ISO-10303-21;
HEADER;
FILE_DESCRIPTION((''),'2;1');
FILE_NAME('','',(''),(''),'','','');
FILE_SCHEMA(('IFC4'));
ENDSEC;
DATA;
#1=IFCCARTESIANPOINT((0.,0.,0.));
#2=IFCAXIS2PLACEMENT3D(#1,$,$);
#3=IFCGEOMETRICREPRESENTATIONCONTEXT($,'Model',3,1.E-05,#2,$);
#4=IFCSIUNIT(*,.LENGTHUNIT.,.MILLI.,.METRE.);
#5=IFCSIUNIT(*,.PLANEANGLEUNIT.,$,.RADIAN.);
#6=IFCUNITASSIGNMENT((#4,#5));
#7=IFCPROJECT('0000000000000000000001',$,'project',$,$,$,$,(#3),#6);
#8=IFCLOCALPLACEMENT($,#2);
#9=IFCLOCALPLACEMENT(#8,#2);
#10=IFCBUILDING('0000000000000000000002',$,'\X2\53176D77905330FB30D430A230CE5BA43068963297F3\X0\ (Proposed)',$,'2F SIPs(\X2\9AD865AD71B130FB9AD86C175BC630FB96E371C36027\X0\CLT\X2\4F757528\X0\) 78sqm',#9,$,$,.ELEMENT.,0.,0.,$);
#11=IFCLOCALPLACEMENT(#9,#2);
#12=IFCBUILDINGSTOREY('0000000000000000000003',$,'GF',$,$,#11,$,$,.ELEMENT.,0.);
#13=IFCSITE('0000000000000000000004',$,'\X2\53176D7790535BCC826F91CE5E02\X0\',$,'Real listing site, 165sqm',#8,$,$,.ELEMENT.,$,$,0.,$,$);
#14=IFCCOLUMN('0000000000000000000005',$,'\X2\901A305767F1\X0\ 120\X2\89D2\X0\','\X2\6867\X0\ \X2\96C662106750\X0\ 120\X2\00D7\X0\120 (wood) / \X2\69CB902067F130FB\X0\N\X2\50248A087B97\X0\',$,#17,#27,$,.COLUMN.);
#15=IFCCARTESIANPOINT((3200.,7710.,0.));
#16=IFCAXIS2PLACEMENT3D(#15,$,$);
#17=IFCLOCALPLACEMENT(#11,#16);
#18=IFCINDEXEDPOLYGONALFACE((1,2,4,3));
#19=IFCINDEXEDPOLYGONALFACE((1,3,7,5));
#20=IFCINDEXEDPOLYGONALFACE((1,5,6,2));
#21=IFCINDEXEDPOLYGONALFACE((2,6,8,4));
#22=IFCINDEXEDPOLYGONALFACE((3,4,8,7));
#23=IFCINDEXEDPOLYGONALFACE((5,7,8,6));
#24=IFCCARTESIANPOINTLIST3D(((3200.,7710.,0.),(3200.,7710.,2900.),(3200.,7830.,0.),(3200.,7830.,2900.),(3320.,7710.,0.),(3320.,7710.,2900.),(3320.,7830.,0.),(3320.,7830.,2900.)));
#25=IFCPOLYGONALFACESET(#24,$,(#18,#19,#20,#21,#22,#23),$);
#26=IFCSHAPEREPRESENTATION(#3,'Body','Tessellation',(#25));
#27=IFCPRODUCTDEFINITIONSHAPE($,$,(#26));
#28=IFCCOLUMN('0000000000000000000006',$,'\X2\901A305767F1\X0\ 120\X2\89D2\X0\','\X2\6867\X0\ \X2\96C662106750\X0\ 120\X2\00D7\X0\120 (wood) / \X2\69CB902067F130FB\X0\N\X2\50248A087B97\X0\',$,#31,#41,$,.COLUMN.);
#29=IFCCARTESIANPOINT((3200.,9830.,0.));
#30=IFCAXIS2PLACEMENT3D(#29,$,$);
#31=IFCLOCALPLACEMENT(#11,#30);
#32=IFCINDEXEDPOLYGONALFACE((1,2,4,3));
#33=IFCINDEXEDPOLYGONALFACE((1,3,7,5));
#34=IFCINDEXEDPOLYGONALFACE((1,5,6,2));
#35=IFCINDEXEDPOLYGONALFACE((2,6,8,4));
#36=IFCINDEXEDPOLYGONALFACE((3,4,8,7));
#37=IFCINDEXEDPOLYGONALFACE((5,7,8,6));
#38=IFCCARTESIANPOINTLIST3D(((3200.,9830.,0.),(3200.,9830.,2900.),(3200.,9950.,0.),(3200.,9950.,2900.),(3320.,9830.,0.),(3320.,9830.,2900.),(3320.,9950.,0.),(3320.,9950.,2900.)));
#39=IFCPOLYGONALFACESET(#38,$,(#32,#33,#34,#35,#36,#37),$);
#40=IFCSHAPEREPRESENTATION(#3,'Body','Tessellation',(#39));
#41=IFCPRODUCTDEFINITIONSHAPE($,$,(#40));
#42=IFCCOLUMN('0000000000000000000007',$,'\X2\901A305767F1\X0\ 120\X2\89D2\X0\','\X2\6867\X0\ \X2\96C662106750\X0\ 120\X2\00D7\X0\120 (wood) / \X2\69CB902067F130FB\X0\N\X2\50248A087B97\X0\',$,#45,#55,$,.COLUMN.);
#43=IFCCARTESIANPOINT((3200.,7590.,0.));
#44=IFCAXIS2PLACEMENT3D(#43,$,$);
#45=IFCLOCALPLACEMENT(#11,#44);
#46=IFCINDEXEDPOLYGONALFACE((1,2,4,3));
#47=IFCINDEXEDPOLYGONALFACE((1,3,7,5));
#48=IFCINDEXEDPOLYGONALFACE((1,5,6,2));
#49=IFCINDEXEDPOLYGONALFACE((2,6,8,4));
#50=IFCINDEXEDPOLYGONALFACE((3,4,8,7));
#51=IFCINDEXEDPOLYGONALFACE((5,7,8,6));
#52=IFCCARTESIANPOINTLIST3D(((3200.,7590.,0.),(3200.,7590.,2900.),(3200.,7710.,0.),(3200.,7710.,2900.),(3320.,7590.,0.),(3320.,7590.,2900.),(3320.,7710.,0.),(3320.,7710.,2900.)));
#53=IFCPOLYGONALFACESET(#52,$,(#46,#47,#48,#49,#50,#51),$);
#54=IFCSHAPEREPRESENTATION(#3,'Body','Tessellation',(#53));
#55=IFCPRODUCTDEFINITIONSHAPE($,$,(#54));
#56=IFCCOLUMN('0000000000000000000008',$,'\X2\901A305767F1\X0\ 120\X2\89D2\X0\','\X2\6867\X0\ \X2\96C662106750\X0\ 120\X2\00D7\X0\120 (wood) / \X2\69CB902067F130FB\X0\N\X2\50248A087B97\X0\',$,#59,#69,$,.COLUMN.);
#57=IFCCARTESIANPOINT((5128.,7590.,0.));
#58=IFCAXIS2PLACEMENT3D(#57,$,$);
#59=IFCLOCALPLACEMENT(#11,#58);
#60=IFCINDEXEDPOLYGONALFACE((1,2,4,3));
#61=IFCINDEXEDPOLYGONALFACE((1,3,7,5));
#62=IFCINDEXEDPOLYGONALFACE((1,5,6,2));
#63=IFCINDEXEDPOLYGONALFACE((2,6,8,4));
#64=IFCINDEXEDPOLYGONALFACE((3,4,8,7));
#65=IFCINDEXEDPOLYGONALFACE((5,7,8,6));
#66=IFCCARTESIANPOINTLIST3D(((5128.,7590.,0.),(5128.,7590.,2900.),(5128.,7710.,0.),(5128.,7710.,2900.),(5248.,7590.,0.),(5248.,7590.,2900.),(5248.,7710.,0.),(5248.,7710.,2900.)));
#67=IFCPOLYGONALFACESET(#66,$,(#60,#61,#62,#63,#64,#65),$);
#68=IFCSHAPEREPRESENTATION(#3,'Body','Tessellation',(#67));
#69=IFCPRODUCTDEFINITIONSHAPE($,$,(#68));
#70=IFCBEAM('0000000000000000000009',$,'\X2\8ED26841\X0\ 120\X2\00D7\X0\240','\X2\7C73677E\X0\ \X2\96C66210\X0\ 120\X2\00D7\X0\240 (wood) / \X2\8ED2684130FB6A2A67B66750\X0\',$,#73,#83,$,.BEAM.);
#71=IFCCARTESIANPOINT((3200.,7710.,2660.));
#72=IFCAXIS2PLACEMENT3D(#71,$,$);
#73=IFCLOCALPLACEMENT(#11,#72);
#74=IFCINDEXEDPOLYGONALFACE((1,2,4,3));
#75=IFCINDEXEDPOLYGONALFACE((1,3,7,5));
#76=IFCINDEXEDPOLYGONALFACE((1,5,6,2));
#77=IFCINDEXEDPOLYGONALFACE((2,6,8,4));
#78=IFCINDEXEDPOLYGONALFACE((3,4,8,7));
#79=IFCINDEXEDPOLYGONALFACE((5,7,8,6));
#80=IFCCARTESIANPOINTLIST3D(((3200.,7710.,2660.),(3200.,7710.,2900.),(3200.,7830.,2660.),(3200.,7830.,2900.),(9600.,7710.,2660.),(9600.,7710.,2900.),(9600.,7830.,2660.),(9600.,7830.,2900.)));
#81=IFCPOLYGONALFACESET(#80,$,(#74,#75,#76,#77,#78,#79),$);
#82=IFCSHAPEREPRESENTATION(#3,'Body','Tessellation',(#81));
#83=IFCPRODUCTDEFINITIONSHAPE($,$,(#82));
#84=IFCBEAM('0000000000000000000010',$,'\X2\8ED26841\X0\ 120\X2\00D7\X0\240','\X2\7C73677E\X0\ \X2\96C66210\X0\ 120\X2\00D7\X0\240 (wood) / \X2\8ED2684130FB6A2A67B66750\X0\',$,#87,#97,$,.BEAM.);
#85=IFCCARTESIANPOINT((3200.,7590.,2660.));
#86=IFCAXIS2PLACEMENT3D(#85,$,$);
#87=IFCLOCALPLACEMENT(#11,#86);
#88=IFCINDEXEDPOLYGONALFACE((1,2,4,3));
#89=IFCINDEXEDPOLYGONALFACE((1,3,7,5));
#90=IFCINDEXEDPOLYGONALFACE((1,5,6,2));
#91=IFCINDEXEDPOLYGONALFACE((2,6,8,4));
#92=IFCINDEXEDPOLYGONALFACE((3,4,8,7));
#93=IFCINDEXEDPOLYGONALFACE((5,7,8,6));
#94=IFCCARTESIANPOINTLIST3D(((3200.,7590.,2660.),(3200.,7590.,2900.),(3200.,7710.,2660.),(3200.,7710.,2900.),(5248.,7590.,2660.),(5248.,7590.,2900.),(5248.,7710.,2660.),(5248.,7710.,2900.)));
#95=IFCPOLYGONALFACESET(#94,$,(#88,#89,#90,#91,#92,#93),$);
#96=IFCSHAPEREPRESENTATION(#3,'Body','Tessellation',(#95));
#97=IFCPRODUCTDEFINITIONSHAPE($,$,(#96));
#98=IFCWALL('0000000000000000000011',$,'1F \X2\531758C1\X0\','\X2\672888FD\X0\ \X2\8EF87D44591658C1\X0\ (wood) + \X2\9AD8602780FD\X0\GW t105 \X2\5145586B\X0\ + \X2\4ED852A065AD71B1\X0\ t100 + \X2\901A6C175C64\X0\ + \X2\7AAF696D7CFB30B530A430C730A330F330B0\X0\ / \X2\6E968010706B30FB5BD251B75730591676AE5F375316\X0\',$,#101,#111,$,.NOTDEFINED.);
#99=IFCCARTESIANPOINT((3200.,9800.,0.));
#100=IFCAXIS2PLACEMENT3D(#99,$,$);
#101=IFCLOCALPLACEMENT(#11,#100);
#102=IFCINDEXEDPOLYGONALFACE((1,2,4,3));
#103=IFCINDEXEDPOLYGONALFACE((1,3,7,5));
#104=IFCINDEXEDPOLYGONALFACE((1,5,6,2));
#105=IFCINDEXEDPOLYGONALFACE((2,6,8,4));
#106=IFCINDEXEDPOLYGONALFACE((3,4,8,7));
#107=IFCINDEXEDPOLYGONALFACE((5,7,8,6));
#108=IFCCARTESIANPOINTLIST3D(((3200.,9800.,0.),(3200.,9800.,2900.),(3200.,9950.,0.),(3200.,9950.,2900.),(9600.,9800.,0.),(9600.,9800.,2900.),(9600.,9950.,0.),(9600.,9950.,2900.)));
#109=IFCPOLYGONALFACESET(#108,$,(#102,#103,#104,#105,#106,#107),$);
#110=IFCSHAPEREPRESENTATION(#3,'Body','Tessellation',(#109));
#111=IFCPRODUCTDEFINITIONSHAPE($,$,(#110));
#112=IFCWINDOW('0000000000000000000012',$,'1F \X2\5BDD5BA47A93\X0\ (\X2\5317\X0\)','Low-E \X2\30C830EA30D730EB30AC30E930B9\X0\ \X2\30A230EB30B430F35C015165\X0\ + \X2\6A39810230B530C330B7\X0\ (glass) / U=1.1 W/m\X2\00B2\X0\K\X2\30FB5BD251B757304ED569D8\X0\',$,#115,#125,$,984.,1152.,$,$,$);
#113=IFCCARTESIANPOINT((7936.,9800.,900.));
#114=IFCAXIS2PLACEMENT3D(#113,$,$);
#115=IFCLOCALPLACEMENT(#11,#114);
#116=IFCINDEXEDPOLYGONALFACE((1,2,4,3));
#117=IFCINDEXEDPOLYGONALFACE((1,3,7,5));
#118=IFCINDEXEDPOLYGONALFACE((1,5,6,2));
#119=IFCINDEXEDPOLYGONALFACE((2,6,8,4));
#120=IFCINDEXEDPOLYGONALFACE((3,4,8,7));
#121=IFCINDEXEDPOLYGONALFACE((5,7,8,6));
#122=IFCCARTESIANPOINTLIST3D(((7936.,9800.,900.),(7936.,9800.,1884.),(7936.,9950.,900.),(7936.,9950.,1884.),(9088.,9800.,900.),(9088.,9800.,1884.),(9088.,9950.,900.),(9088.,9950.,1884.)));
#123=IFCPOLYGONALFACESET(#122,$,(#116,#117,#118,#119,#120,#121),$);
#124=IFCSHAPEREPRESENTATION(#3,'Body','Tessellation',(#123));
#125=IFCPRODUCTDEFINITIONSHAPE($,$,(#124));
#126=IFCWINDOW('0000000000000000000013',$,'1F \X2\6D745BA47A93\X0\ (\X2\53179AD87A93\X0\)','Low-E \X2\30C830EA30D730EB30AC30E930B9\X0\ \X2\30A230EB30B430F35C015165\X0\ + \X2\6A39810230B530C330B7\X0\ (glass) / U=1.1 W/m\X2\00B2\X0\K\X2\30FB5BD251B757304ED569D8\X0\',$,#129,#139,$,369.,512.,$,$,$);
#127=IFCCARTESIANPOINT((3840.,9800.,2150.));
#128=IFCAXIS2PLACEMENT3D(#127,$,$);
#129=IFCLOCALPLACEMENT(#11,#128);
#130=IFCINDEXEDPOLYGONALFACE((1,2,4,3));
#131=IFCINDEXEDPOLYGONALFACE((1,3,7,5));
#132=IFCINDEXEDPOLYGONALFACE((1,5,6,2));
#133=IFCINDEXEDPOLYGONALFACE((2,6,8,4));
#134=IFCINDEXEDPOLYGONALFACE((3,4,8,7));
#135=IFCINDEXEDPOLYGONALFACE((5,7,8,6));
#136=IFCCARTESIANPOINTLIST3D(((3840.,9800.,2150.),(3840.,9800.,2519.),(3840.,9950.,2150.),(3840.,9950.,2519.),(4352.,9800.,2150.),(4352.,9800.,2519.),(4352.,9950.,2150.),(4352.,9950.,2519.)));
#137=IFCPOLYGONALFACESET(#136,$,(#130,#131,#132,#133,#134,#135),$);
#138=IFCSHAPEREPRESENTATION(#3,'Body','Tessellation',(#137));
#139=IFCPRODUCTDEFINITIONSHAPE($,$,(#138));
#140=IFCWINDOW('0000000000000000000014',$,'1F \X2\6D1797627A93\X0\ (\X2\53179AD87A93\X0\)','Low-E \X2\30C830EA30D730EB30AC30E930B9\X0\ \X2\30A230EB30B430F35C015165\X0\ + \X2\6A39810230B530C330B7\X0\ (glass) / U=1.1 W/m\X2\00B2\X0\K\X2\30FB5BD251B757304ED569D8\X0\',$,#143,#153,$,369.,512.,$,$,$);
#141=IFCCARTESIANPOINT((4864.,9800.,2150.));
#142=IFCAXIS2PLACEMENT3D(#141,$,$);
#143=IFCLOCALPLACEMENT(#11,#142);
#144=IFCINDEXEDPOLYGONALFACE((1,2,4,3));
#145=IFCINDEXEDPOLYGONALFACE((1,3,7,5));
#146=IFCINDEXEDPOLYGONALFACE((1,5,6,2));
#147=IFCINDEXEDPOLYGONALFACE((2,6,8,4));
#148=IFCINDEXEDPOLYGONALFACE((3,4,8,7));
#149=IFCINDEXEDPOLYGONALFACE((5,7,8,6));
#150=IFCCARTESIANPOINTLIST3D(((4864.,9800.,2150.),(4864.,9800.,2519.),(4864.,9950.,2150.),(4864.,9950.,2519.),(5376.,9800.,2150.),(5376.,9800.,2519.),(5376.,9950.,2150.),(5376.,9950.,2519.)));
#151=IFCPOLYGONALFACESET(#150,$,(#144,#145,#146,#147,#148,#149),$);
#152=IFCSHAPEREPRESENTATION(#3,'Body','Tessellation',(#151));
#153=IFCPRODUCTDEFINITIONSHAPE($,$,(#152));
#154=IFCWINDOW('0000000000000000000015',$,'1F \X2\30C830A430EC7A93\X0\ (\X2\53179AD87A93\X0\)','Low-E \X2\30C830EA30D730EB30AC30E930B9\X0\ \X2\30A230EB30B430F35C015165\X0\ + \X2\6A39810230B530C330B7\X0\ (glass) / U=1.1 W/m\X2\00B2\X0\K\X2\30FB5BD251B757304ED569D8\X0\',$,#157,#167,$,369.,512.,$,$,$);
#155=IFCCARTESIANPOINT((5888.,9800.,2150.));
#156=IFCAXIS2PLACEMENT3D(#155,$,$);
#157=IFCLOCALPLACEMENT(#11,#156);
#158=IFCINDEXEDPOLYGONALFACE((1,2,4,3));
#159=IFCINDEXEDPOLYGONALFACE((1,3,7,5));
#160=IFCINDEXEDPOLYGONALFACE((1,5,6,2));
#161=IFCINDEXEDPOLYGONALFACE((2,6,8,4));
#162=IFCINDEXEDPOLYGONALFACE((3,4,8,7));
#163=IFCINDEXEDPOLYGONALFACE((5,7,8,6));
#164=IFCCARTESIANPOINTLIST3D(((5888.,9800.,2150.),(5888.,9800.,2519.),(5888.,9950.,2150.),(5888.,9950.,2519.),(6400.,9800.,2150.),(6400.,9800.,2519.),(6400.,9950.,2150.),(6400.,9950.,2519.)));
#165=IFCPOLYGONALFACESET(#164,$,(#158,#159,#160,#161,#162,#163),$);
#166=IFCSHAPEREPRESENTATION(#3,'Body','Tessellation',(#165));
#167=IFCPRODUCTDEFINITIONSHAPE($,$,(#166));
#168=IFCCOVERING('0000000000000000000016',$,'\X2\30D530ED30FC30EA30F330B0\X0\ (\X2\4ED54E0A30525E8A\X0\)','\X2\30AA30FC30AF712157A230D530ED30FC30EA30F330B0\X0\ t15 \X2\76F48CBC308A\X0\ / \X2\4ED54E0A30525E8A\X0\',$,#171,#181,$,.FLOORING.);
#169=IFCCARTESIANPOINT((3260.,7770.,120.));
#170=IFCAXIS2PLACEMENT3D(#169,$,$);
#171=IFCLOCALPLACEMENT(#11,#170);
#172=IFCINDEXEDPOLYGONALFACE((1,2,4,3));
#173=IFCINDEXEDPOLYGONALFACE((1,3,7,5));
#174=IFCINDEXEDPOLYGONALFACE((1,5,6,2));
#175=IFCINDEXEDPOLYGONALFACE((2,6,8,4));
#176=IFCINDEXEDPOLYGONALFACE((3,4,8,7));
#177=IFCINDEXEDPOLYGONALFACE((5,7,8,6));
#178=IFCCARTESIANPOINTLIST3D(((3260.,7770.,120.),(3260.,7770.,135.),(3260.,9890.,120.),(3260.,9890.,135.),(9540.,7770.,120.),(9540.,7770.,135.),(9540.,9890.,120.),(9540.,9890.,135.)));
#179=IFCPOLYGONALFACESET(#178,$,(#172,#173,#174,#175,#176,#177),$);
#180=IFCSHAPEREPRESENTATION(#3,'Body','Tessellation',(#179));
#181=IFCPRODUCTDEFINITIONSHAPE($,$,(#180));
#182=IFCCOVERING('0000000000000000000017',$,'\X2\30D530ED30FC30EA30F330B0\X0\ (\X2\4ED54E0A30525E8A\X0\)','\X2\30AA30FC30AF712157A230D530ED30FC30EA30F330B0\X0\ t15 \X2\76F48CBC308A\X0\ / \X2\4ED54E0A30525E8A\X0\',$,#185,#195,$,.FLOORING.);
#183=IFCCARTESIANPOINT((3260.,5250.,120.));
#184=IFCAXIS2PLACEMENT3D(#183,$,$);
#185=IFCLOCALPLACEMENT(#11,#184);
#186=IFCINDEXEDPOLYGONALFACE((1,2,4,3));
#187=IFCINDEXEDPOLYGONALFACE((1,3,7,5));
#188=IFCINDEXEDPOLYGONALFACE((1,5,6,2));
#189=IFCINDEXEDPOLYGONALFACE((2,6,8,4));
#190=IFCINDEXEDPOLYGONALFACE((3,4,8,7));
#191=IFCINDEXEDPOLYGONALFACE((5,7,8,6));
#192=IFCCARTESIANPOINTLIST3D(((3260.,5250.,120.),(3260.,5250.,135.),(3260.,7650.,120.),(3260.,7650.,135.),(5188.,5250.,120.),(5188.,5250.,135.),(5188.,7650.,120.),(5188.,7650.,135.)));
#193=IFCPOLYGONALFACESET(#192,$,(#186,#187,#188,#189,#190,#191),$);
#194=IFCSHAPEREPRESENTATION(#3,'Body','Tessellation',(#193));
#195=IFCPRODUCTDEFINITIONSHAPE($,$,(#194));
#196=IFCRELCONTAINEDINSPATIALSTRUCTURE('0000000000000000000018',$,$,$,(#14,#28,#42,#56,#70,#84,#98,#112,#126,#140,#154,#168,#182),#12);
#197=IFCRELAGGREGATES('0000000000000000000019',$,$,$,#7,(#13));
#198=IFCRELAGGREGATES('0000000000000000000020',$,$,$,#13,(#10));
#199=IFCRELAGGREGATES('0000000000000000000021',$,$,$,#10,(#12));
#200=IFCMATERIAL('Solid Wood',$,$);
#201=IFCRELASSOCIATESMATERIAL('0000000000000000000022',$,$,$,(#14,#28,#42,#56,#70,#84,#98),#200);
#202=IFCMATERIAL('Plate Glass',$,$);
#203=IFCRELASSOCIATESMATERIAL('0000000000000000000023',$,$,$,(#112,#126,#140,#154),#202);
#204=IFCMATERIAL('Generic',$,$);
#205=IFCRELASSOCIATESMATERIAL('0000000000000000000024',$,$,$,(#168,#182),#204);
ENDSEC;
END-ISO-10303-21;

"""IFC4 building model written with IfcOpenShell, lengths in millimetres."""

from ifc_helpers import new_model, si_unit, frame, frame_2d, origin, place, context, project, spatial, rectangle, extrude, material, element, fill, save


model = new_model("IFC4")

# Units and contexts
model_context = context("Model", 3, precision=1e-05, world=origin())
ifc_project = project(units=[si_unit("LENGTHUNIT", "METRE", prefix="MILLI"), si_unit("PLANEANGLEUNIT", "RADIAN")], contexts=[model_context])

# Site, building, storey
site_placement = place(None, origin())
site = spatial("IfcSite", under=ifc_project, at=site_placement, Name="北海道富良野市", ObjectType="Real listing site, 165sqm", CompositionType="ELEMENT", RefElevation=0.0)
building_placement = place(site_placement, origin())
building = spatial("IfcBuilding", under=site, at=building_placement, Name="北海道・ピアノ室と防音 (Proposed)", ObjectType="2F SIPs(高断熱・高気密・難燃性CLT併用) 78sqm", CompositionType="ELEMENT", ElevationOfRefHeight=0.0, ElevationOfTerrain=0.0)
storey_placement = place(building_placement, origin())
storey = spatial("IfcBuildingStorey", under=building, at=storey_placement, Name="GF", CompositionType="ELEMENT", Elevation=0.0)

# Columns
ifc_material_1 = material(Name="Solid Wood")
column_1_placement = place(storey_placement, frame((3200.0, 7710.0, 0.0)))
element("IfcColumn", 1, at=column_1_placement, inside=storey, material=ifc_material_1, Name="通し柱 120角", Description="桧 集成材 120×120 (wood) / 構造柱・N値計算", PredefinedType="COLUMN", context=model_context, shape_type="SweptSolid", body=[
    extrude(rectangle(XDim=120.0, YDim=120.0, at=frame_2d((60.0, 60.0))), frame((3200.0, 7710.0, 0.0)), (0.0, 0.0, 1.0), 2900.0),
])
column_2_placement = place(storey_placement, frame((3200.0, 9830.0, 0.0)))
element("IfcColumn", 2, at=column_2_placement, inside=storey, material=ifc_material_1, Name="通し柱 120角", Description="桧 集成材 120×120 (wood) / 構造柱・N値計算", PredefinedType="COLUMN", context=model_context, shape_type="SweptSolid", body=[
    extrude(rectangle(XDim=120.0, YDim=120.0, at=frame_2d((60.0, 60.0))), frame((3200.0, 9830.0, 0.0)), (0.0, 0.0, 1.0), 2900.0),
])
column_3_placement = place(storey_placement, frame((3200.0, 7590.0, 0.0)))
element("IfcColumn", 3, at=column_3_placement, inside=storey, material=ifc_material_1, Name="通し柱 120角", Description="桧 集成材 120×120 (wood) / 構造柱・N値計算", PredefinedType="COLUMN", context=model_context, shape_type="SweptSolid", body=[
    extrude(rectangle(XDim=120.0, YDim=120.0, at=frame_2d((60.0, 60.0))), frame((3200.0, 7590.0, 0.0)), (0.0, 0.0, 1.0), 2900.0),
])
column_4_placement = place(storey_placement, frame((5128.0, 7590.0, 0.0)))
element("IfcColumn", 4, at=column_4_placement, inside=storey, material=ifc_material_1, Name="通し柱 120角", Description="桧 集成材 120×120 (wood) / 構造柱・N値計算", PredefinedType="COLUMN", context=model_context, shape_type="SweptSolid", body=[
    extrude(rectangle(XDim=120.0, YDim=120.0, at=frame_2d((60.0, 60.0))), frame((5128.0, 7590.0, 0.0)), (0.0, 0.0, 1.0), 2900.0),
])

# Beams
beam_1_placement = place(storey_placement, frame((3200.0, 7710.0, 2660.0)))
element("IfcBeam", 5, at=beam_1_placement, inside=storey, material=ifc_material_1, Name="軒桁 120×240", Description="米松 集成 120×240 (wood) / 軒桁・横架材", PredefinedType="BEAM", context=model_context, shape_type="SweptSolid", body=[
    extrude(rectangle(XDim=6400.0, YDim=120.0, at=frame_2d((3200.0, 60.0))), frame((3200.0, 7710.0, 2660.0)), (0.0, 0.0, 1.0), 240.0),
])
beam_2_placement = place(storey_placement, frame((3200.0, 7590.0, 2660.0)))
element("IfcBeam", 6, at=beam_2_placement, inside=storey, material=ifc_material_1, Name="軒桁 120×240", Description="米松 集成 120×240 (wood) / 軒桁・横架材", PredefinedType="BEAM", context=model_context, shape_type="SweptSolid", body=[
    extrude(rectangle(XDim=2048.0, YDim=120.0, at=frame_2d((1024.0, 60.0))), frame((3200.0, 7590.0, 2660.0)), (0.0, 0.0, 1.0), 240.0),
])

# Wall, openings, windows
wall_1_placement = place(storey_placement, frame((3200.0, 9800.0, 0.0)))
wall_1 = element("IfcWall", 7, at=wall_1_placement, inside=storey, material=ifc_material_1, Name="1F 北壁", Description="木製 軸組外壁 (wood) + 高性能GW t105 充填 + 付加断熱 t100 + 通気層 + 窯業系サイディング / 準耐火・寒冷地外皮強化", PredefinedType="NOTDEFINED", context=model_context, shape_type="SweptSolid", body=[
    extrude(rectangle(XDim=6400.0, YDim=150.0, at=frame_2d((3200.0, 75.0))), frame((3200.0, 9800.0, 0.0)), (0.0, 0.0, 1.0), 2900.0),
])
opening_1_placement = place(storey_placement, frame((7936.0, 9800.0, 900.0)))
opening_1 = element("IfcOpeningElement", 8, at=opening_1_placement, cuts=wall_1, PredefinedType="NOTDEFINED", context=model_context, shape_type="SweptSolid", body=[
    extrude(rectangle(XDim=1152.0, YDim=150.0, at=frame_2d((576.0, 75.0))), frame((7936.0, 9800.0, 900.0)), (0.0, 0.0, 1.0), 984.0),
])
opening_2_placement = place(storey_placement, frame((3840.0, 9800.0, 2150.0)))
opening_2 = element("IfcOpeningElement", 9, at=opening_2_placement, cuts=wall_1, PredefinedType="NOTDEFINED", context=model_context, shape_type="SweptSolid", body=[
    extrude(rectangle(XDim=512.0, YDim=150.0, at=frame_2d((256.0, 75.0))), frame((3840.0, 9800.0, 2150.0)), (0.0, 0.0, 1.0), 369.0),
])
opening_3_placement = place(storey_placement, frame((4864.0, 9800.0, 2150.0)))
opening_3 = element("IfcOpeningElement", 10, at=opening_3_placement, cuts=wall_1, PredefinedType="NOTDEFINED", context=model_context, shape_type="SweptSolid", body=[
    extrude(rectangle(XDim=512.0, YDim=150.0, at=frame_2d((256.0, 75.0))), frame((4864.0, 9800.0, 2150.0)), (0.0, 0.0, 1.0), 369.0),
])
opening_4_placement = place(storey_placement, frame((5888.0, 9800.0, 2150.0)))
opening_4 = element("IfcOpeningElement", 11, at=opening_4_placement, cuts=wall_1, PredefinedType="NOTDEFINED", context=model_context, shape_type="SweptSolid", body=[
    extrude(rectangle(XDim=512.0, YDim=150.0, at=frame_2d((256.0, 75.0))), frame((5888.0, 9800.0, 2150.0)), (0.0, 0.0, 1.0), 369.0),
])
ifc_material_2 = material(Name="Plate Glass")
window_1_placement = place(storey_placement, frame((7936.0, 9800.0, 900.0)))
window_1 = element("IfcWindow", 12, at=window_1_placement, inside=storey, material=ifc_material_2, Name="1F 寝室窓 (北)", Description="Low-E トリプルガラス アルゴン封入 + 樹脂サッシ (glass) / U=1.1 W/m²K・寒冷地仕様", OverallHeight=984.0, OverallWidth=1152.0, context=model_context, shape_type="SweptSolid", body=[
    extrude(rectangle(XDim=1152.0, YDim=150.0, at=frame_2d((576.0, 75.0))), frame((7936.0, 9800.0, 900.0)), (0.0, 0.0, 1.0), 984.0),
])
fill(opening_1, window_1)
window_2_placement = place(storey_placement, frame((3840.0, 9800.0, 2150.0)))
window_2 = element("IfcWindow", 13, at=window_2_placement, inside=storey, material=ifc_material_2, Name="1F 浴室窓 (北高窓)", Description="Low-E トリプルガラス アルゴン封入 + 樹脂サッシ (glass) / U=1.1 W/m²K・寒冷地仕様", OverallHeight=369.0, OverallWidth=512.0, context=model_context, shape_type="SweptSolid", body=[
    extrude(rectangle(XDim=512.0, YDim=150.0, at=frame_2d((256.0, 75.0))), frame((3840.0, 9800.0, 2150.0)), (0.0, 0.0, 1.0), 369.0),
])
fill(opening_2, window_2)
window_3_placement = place(storey_placement, frame((4864.0, 9800.0, 2150.0)))
window_3 = element("IfcWindow", 14, at=window_3_placement, inside=storey, material=ifc_material_2, Name="1F 洗面窓 (北高窓)", Description="Low-E トリプルガラス アルゴン封入 + 樹脂サッシ (glass) / U=1.1 W/m²K・寒冷地仕様", OverallHeight=369.0, OverallWidth=512.0, context=model_context, shape_type="SweptSolid", body=[
    extrude(rectangle(XDim=512.0, YDim=150.0, at=frame_2d((256.0, 75.0))), frame((4864.0, 9800.0, 2150.0)), (0.0, 0.0, 1.0), 369.0),
])
fill(opening_3, window_3)
window_4_placement = place(storey_placement, frame((5888.0, 9800.0, 2150.0)))
window_4 = element("IfcWindow", 15, at=window_4_placement, inside=storey, material=ifc_material_2, Name="1F トイレ窓 (北高窓)", Description="Low-E トリプルガラス アルゴン封入 + 樹脂サッシ (glass) / U=1.1 W/m²K・寒冷地仕様", OverallHeight=369.0, OverallWidth=512.0, context=model_context, shape_type="SweptSolid", body=[
    extrude(rectangle(XDim=512.0, YDim=150.0, at=frame_2d((256.0, 75.0))), frame((5888.0, 9800.0, 2150.0)), (0.0, 0.0, 1.0), 369.0),
])
fill(opening_4, window_4)

# Coverings
ifc_material_3 = material(Name="Generic")
covering_1_placement = place(storey_placement, frame((3260.0, 7770.0, 120.0)))
element("IfcCovering", 16, at=covering_1_placement, inside=storey, material=ifc_material_3, Name="フローリング (仕上げ床)", Description="オーク無垢フローリング t15 直貼り / 仕上げ床", PredefinedType="FLOORING", context=model_context, shape_type="SweptSolid", body=[
    extrude(rectangle(XDim=6280.0, YDim=2120.0, at=frame_2d((3140.0, 1060.0))), frame((3260.0, 7770.0, 120.0)), (0.0, 0.0, 1.0), 15.0),
])
covering_2_placement = place(storey_placement, frame((3260.0, 5250.0, 120.0)))
element("IfcCovering", 17, at=covering_2_placement, inside=storey, material=ifc_material_3, Name="フローリング (仕上げ床)", Description="オーク無垢フローリング t15 直貼り / 仕上げ床", PredefinedType="FLOORING", context=model_context, shape_type="SweptSolid", body=[
    extrude(rectangle(XDim=1928.0, YDim=2400.0, at=frame_2d((964.0, 1200.0))), frame((3260.0, 5250.0, 120.0)), (0.0, 0.0, 1.0), 15.0),
])

save(model, "model.ifc")
